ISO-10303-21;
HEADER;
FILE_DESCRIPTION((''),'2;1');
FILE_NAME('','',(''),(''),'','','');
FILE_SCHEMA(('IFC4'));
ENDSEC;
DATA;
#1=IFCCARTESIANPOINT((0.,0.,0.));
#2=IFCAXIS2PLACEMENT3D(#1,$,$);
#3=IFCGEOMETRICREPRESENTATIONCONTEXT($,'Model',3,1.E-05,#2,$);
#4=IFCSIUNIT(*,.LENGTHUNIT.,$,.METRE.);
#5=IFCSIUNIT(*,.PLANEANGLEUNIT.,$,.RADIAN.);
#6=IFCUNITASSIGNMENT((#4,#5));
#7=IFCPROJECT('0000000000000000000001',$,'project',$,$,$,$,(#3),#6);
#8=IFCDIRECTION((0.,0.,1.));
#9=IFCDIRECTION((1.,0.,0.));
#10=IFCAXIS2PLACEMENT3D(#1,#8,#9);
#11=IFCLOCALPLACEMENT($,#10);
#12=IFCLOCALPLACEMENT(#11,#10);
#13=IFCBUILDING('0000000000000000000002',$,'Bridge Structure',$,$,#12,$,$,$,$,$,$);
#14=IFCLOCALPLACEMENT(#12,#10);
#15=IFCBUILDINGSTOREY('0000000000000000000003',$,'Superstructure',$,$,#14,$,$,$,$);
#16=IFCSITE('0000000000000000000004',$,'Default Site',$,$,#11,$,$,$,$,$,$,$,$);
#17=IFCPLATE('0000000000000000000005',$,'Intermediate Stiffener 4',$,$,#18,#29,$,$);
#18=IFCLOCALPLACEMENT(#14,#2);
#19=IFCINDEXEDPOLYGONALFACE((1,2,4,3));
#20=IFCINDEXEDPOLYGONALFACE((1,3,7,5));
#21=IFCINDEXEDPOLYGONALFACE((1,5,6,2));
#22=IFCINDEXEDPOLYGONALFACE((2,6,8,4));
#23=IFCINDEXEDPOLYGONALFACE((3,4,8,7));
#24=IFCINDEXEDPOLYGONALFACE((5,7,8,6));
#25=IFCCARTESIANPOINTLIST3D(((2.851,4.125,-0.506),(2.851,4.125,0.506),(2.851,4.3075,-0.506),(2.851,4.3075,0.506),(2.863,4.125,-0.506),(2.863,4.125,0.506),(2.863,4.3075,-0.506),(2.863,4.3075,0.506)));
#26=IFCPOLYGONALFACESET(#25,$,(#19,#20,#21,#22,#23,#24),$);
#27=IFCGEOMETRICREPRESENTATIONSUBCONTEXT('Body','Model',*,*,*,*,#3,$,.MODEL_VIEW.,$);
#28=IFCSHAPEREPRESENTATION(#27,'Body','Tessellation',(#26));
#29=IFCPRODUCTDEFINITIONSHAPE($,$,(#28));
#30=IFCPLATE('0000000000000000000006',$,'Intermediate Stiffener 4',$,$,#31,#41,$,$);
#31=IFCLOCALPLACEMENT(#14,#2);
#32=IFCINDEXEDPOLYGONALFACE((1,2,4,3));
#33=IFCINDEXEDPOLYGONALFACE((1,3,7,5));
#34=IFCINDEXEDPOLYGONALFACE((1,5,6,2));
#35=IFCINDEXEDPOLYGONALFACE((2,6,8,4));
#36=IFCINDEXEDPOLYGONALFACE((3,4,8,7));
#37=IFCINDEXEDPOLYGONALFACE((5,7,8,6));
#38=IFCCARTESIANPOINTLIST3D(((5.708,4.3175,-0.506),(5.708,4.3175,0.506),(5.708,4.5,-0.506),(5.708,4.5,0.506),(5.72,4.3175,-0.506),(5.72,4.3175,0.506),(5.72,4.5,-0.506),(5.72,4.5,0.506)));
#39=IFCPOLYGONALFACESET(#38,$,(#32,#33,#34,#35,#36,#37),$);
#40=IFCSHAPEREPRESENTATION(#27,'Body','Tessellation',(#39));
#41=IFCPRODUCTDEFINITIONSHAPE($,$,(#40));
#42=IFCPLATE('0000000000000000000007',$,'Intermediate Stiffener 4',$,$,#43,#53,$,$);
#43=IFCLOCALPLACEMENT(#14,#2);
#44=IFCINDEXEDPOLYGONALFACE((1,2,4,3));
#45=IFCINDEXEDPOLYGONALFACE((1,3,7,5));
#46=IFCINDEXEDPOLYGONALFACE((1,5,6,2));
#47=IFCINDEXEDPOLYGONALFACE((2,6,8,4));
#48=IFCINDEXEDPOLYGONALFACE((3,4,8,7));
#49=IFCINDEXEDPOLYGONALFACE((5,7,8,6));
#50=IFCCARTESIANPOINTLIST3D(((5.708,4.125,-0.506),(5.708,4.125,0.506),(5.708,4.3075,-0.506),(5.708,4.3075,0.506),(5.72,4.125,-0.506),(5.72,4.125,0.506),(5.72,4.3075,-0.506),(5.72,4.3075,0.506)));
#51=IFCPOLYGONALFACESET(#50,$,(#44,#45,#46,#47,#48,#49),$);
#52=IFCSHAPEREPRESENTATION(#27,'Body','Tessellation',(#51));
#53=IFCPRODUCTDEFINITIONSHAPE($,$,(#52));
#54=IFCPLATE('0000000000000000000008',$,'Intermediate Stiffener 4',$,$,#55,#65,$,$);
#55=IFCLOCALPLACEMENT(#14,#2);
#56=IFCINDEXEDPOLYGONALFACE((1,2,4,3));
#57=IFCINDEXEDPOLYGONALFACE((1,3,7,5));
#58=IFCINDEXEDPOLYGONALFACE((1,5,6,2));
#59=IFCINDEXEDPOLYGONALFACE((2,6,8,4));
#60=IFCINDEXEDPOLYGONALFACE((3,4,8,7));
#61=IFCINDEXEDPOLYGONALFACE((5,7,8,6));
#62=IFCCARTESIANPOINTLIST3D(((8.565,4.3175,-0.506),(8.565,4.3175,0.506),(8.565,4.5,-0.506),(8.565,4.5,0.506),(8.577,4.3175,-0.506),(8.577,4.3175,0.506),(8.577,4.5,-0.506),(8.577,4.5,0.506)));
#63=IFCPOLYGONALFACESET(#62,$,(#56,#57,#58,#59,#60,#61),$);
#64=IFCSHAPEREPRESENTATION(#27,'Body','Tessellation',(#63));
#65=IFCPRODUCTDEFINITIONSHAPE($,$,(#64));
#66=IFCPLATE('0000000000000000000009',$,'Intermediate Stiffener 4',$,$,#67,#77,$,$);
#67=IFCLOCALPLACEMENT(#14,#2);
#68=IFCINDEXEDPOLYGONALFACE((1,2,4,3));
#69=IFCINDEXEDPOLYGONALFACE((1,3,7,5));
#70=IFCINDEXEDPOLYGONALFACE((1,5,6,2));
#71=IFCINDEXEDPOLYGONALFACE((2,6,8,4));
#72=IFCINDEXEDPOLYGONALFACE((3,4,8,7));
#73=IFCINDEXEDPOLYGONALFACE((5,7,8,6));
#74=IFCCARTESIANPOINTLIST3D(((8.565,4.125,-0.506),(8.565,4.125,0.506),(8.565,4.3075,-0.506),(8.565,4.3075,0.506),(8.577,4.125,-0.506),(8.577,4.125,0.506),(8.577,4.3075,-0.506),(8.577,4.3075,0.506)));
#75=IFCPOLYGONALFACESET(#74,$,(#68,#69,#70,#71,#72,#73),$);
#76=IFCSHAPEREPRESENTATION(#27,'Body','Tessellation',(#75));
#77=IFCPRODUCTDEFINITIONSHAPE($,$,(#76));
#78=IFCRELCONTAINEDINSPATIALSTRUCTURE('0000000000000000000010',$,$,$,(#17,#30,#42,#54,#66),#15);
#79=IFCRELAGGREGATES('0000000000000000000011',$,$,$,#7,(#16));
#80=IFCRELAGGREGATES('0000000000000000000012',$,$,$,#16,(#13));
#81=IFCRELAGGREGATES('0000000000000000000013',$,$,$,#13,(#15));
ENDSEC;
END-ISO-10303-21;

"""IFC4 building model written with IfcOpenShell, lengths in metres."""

from ifc_helpers import new_model, si_unit, frame, origin, origin_with_axes, origin_2d_with_axis, place, context, subcontext, project, spatial, rectangle, extrude, element, save


model = new_model("IFC4")

# Units and contexts
model_context = context("Model", 3, precision=1e-05, world=origin())
body_context = subcontext(model_context, "Body", "Model", "MODEL_VIEW")
ifc_project = project(units=[si_unit("LENGTHUNIT", "METRE"), si_unit("PLANEANGLEUNIT", "RADIAN")], contexts=[model_context])

# Site, building, storey
site_placement = place(None, origin_with_axes())
site = spatial("IfcSite", under=ifc_project, at=site_placement, Name="Default Site")
building_placement = place(site_placement, origin_with_axes())
building = spatial("IfcBuilding", under=site, at=building_placement, Name="Bridge Structure")
storey_placement = place(building_placement, origin_with_axes())
storey = spatial("IfcBuildingStorey", under=building, at=storey_placement, Name="Superstructure")

# Plates
for number, where, z_axis, x_axis, name in (
    (1, (2.857, 4.2163, -0.506), (0.0, 0.0, 1.0), (1.0, 0.0, 0.0), "Intermediate Stiffener 4"),
    (2, (5.714, 4.4088, -0.506), (0.0, 0.0, 1.0), (1.0, 0.0, 0.0), "Intermediate Stiffener 4"),
    (3, (5.714, 4.2163, -0.506), (0.0, 0.0, 1.0), (1.0, 0.0, 0.0), "Intermediate Stiffener 4"),
    (4, (8.571, 4.4088, -0.506), (0.0, 0.0, 1.0), (1.0, 0.0, 0.0), "Intermediate Stiffener 4"),
    (5, (8.571, 4.2163, -0.506), (0.0, 0.0, 1.0), (1.0, 0.0, 0.0), "Intermediate Stiffener 4"),
):
    element("IfcPlate", number, at=place(storey_placement, frame(where, z_axis=z_axis, x_axis=x_axis)), inside=storey, Name=name, context=body_context, shape_type="SweptSolid", body=[
        extrude(rectangle(XDim=0.012, YDim=0.1825, at=origin_2d_with_axis()), origin_with_axes(), (0.0, 0.0, 1.0), 1.012),
    ])

save(model, "model.ifc")
